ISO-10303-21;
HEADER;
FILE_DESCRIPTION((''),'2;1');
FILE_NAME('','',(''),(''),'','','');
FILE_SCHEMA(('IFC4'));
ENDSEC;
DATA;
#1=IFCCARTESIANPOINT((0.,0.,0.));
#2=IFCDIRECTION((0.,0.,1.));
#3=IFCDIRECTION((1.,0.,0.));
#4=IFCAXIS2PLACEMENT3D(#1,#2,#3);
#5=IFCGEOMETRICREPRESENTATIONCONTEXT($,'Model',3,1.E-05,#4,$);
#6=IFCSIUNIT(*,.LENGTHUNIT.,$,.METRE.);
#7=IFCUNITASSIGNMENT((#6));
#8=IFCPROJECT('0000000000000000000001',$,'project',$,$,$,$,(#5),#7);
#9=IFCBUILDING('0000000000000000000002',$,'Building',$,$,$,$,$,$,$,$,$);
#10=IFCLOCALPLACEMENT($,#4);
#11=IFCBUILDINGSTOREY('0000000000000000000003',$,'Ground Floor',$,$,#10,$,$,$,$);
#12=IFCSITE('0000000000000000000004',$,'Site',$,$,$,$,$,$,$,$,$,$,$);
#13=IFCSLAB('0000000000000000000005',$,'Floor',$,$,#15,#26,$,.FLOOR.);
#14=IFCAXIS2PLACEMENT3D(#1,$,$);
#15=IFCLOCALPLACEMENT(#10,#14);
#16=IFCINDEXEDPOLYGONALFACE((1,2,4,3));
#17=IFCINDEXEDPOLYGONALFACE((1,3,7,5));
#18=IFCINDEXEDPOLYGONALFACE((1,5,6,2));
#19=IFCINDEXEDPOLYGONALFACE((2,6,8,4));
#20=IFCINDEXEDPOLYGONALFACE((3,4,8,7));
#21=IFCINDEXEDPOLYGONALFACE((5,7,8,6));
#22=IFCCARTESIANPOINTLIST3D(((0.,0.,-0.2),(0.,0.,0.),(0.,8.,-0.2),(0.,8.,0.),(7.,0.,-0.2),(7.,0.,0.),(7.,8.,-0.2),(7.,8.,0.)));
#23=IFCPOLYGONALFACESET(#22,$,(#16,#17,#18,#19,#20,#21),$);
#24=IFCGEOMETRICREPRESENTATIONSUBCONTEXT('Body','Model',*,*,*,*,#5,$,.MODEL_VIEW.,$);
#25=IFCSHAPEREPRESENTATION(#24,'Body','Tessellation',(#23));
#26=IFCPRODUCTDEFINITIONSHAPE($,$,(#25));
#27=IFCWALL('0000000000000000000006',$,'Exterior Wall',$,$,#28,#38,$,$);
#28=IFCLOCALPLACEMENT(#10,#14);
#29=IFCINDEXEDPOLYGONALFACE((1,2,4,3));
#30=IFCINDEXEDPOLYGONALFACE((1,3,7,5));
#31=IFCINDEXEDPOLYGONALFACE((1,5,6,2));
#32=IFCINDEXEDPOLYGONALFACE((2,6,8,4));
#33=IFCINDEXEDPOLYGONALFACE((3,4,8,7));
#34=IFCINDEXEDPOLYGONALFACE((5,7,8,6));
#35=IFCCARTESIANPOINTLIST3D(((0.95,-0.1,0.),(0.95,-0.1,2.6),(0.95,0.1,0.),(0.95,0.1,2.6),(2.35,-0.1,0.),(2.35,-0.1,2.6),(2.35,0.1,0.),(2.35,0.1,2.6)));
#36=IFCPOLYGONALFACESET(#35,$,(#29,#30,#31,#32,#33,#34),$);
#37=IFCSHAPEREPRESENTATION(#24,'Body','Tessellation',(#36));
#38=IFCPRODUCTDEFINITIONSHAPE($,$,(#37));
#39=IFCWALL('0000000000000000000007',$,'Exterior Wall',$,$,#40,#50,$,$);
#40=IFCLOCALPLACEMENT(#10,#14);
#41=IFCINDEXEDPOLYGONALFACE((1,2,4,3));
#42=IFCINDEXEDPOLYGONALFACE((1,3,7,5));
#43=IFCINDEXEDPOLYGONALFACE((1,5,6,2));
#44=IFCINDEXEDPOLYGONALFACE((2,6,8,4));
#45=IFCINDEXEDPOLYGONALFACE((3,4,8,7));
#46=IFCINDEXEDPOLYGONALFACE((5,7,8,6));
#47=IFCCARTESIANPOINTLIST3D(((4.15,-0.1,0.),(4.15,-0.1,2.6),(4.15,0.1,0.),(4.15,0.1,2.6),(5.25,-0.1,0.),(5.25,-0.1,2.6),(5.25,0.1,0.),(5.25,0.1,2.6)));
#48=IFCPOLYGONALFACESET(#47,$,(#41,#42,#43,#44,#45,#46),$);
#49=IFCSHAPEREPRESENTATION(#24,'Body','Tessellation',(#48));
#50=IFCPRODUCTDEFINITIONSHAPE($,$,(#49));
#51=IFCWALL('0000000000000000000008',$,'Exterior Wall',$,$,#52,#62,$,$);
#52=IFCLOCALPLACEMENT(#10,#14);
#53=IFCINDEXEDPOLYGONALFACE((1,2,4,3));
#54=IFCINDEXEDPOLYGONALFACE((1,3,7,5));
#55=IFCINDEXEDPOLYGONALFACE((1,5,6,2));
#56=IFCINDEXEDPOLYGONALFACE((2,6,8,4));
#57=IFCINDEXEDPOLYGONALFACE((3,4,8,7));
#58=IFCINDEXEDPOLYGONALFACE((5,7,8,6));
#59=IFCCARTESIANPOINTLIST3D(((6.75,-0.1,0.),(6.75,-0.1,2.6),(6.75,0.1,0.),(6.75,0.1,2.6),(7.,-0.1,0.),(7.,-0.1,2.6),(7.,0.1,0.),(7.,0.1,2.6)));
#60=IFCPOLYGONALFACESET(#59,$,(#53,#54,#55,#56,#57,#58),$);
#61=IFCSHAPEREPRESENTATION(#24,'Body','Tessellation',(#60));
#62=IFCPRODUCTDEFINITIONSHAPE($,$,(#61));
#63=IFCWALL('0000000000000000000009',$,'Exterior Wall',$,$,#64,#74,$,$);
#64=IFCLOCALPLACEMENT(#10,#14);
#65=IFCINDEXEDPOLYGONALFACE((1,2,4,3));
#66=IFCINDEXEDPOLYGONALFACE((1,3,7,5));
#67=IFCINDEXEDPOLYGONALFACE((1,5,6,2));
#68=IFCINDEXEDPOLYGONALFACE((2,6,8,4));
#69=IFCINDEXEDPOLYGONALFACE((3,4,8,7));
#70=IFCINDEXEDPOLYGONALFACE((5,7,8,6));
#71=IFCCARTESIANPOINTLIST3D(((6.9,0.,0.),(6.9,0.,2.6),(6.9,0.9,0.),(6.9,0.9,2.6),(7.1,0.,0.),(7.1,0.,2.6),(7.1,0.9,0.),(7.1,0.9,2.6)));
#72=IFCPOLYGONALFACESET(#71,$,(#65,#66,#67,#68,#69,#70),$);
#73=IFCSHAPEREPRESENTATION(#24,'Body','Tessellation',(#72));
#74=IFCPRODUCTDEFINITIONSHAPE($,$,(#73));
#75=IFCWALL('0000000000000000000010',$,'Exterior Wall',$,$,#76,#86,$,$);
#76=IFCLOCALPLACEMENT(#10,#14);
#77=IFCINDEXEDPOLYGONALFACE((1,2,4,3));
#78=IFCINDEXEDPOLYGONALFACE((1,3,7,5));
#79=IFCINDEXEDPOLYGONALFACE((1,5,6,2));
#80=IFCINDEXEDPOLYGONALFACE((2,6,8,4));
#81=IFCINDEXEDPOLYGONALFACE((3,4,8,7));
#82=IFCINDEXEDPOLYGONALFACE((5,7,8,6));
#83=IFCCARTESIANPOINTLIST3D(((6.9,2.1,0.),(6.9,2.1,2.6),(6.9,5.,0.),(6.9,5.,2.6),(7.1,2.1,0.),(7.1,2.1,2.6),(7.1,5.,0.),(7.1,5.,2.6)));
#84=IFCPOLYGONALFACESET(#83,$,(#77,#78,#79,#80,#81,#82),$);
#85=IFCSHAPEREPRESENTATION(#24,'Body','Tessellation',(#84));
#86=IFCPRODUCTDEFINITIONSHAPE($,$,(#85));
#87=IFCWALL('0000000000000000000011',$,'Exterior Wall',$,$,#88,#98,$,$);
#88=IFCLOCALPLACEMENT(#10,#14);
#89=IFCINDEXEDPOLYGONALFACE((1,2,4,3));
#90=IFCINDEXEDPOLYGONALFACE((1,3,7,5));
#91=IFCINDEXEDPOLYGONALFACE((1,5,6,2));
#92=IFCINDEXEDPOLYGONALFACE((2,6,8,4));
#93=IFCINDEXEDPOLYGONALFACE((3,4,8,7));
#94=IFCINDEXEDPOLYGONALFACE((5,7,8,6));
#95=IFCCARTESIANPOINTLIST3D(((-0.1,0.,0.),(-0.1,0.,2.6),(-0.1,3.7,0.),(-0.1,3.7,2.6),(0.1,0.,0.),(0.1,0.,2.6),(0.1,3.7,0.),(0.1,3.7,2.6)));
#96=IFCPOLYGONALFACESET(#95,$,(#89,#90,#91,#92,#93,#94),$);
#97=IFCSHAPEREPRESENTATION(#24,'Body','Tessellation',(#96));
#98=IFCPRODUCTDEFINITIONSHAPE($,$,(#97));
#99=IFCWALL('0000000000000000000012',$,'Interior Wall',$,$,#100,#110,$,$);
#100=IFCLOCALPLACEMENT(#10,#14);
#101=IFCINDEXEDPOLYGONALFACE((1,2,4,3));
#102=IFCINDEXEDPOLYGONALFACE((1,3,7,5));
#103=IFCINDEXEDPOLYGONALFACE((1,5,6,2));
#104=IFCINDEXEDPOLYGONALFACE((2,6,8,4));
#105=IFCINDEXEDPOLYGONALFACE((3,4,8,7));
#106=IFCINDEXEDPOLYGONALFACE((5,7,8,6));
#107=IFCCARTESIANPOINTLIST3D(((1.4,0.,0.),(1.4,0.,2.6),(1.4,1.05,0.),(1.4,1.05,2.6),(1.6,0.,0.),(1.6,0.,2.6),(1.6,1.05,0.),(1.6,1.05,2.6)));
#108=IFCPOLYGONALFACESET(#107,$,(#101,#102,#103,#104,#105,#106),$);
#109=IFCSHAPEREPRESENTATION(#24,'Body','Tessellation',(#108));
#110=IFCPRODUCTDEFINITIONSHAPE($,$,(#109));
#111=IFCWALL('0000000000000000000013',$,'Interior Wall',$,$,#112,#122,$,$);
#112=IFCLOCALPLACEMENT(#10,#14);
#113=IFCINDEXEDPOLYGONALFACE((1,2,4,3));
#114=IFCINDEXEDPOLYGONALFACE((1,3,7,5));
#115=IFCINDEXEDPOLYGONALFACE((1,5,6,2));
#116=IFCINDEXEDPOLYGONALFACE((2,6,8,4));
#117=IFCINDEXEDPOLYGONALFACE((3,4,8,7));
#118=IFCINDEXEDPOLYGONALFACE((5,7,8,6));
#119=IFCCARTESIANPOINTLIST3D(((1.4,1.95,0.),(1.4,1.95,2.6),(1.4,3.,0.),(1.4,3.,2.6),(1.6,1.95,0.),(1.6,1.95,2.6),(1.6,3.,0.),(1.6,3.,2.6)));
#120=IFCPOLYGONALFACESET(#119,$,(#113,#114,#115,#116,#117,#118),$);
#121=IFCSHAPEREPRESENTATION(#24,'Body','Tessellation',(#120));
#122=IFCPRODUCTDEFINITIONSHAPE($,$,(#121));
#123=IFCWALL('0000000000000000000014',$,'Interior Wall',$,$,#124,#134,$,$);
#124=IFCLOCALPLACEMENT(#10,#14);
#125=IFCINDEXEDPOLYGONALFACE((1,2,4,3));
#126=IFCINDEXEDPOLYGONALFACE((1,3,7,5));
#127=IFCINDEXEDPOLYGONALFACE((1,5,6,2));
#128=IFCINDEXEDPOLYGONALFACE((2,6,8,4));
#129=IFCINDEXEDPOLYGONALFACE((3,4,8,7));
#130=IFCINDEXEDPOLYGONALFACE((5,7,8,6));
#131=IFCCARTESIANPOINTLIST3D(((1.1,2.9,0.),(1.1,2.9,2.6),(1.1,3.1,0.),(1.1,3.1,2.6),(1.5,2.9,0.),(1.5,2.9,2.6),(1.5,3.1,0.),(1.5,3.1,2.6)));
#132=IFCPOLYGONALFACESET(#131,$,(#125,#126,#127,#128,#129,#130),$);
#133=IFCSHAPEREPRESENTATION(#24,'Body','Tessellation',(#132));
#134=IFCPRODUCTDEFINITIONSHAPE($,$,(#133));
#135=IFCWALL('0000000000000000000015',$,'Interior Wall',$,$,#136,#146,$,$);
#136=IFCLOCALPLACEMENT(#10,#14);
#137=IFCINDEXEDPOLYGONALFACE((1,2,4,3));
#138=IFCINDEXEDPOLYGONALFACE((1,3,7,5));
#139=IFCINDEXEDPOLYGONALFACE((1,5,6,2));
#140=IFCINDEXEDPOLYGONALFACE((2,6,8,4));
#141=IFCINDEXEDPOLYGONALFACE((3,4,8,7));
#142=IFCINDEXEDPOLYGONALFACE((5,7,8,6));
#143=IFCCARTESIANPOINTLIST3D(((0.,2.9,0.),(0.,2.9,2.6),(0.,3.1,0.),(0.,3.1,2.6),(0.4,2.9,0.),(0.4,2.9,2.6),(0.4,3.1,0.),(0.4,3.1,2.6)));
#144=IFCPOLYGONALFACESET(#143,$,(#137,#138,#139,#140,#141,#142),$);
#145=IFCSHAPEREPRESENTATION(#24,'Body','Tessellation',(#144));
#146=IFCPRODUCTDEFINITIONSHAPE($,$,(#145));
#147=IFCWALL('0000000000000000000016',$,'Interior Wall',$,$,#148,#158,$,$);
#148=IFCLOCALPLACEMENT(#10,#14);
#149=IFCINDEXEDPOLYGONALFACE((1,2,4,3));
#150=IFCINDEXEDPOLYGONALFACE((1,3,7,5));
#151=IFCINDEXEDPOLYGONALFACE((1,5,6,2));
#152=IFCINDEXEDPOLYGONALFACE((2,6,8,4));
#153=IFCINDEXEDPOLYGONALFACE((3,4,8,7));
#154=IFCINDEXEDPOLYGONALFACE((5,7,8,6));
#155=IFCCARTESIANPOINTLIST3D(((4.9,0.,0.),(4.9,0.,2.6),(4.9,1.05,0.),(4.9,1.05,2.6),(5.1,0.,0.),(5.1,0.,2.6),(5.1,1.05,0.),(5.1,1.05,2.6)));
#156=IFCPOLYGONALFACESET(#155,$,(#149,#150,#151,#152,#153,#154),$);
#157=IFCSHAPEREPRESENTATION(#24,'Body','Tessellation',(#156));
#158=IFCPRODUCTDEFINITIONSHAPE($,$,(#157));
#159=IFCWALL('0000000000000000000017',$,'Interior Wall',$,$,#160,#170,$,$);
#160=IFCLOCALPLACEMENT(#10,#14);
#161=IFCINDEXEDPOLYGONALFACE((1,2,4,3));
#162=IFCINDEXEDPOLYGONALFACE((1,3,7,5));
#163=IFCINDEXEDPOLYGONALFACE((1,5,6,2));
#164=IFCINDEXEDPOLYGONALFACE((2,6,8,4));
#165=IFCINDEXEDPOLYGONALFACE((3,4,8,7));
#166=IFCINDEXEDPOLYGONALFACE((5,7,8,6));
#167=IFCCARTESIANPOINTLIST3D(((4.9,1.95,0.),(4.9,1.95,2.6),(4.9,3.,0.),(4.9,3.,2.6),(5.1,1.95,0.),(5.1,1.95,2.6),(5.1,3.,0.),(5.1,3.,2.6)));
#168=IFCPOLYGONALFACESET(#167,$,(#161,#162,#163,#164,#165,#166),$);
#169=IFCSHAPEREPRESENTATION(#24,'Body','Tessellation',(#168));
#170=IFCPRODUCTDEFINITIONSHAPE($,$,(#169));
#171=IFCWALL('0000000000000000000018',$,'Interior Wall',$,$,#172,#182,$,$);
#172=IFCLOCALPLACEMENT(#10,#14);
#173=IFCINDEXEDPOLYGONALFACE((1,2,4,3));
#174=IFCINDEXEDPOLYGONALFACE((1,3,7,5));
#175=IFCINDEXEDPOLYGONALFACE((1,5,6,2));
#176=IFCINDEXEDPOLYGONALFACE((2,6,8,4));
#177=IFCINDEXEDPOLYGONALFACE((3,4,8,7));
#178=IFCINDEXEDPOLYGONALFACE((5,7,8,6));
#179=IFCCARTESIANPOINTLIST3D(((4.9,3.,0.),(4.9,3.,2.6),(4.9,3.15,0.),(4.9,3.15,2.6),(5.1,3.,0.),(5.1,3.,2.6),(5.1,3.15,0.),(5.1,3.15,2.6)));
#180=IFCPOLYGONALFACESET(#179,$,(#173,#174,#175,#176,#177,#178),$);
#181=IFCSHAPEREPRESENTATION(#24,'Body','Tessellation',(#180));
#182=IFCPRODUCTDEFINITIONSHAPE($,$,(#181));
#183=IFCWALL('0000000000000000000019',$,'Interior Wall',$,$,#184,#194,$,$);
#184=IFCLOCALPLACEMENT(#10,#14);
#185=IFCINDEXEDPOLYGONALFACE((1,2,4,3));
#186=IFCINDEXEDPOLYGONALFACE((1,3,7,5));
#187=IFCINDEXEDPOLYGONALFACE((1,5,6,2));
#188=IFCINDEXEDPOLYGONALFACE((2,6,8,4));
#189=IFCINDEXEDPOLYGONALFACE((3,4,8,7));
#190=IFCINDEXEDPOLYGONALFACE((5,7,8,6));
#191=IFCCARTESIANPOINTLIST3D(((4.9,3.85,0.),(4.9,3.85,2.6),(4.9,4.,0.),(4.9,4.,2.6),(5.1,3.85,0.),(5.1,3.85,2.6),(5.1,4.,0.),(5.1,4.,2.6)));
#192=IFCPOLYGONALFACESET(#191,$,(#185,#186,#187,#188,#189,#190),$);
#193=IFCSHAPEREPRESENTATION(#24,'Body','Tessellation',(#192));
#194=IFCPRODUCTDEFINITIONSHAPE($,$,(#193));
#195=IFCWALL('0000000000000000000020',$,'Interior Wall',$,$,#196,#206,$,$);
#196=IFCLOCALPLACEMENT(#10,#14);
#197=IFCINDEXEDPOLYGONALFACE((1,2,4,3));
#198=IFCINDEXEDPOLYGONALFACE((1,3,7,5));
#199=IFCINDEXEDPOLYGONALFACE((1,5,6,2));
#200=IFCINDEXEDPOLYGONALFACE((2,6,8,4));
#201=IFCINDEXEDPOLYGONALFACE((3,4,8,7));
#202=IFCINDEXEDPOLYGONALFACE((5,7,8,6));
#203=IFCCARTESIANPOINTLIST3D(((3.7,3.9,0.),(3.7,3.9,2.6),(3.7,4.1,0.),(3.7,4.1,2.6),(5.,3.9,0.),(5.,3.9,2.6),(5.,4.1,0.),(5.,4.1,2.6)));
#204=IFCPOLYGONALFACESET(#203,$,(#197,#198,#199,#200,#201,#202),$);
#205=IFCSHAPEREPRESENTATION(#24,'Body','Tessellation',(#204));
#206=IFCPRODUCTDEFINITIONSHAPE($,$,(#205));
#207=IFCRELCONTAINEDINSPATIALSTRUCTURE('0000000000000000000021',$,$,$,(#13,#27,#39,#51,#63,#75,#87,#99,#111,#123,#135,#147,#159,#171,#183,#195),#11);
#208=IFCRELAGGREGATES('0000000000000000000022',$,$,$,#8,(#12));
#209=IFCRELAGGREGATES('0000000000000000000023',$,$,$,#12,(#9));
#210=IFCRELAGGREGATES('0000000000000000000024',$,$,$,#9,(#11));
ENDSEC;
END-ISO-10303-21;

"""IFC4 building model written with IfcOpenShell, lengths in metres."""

from ifc_helpers import new_model, si_unit, frame, origin_with_axes, place, context, subcontext, project, spatial, indexed_curve, outline, extrude, element, save


model = new_model("IFC4")

# Units and contexts
model_context = context("Model", 3, precision=1e-05, world=origin_with_axes())
body_context = subcontext(model_context, "Body", "Model", "MODEL_VIEW")
ifc_project = project(units=[si_unit("LENGTHUNIT", "METRE")], contexts=[model_context])

# Site, building, storey
site = spatial("IfcSite", under=ifc_project, Name="Site")
building = spatial("IfcBuilding", under=site, Name="Building")
storey_placement = place(None, origin_with_axes())
storey = spatial("IfcBuildingStorey", under=building, at=storey_placement, Name="Ground Floor")

# Slab
slab_placement = place(storey_placement, frame((0.0, 0.0, -0.2), z_axis=(0.0, 0.0, 1.0), x_axis=(1.0, 0.0, 0.0)))
element("IfcSlab", 1, at=slab_placement, inside=storey, Name="Floor", PredefinedType="FLOOR", context=body_context, shape_type="SweptSolid", body=[
    extrude(outline(indexed_curve([(0.0, 0.0), (7.0, 0.0), (7.0, 8.0), (0.0, 8.0)])), None, (0.0, 0.0, 1.0), 0.2),
])

# Walls
wall_1_placement = place(storey_placement, frame((0.95, 0.0, 0.0), z_axis=(0.0, 0.0, 1.0), x_axis=(1.0, 0.0, 0.0)))
element("IfcWall", 2, at=wall_1_placement, inside=storey, Name="Exterior Wall", context=body_context, shape_type="SweptSolid", body=[
    extrude(outline(indexed_curve([(0.0, 0.0), (0.0, 0.2), (1.4, 0.2), (1.4, 0.0), (0.0, 0.0)], self_intersect=False)), frame((0.0, -0.1, 0.0), z_axis=(0.0, 0.0, 1.0), x_axis=(1.0, 0.0, 0.0)), (0.0, 0.0, 1.0), 2.6),
])
wall_2_placement = place(storey_placement, frame((4.15, 0.0, 0.0), z_axis=(0.0, 0.0, 1.0), x_axis=(1.0, 0.0, 0.0)))
element("IfcWall", 3, at=wall_2_placement, inside=storey, Name="Exterior Wall", context=body_context, shape_type="SweptSolid", body=[
    extrude(outline(indexed_curve([(0.0, 0.0), (0.0, 0.2), (1.1, 0.2), (1.1, 0.0), (0.0, 0.0)], self_intersect=False)), frame((0.0, -0.1, 0.0), z_axis=(0.0, 0.0, 1.0), x_axis=(1.0, 0.0, 0.0)), (0.0, 0.0, 1.0), 2.6),
])
wall_3_placement = place(storey_placement, frame((6.75, 0.0, 0.0), z_axis=(0.0, 0.0, 1.0), x_axis=(1.0, 0.0, 0.0)))
element("IfcWall", 4, at=wall_3_placement, inside=storey, Name="Exterior Wall", context=body_context, shape_type="SweptSolid", body=[
    extrude(outline(indexed_curve([(0.0, 0.0), (0.0, 0.2), (0.25, 0.2), (0.25, 0.0), (0.0, 0.0)], self_intersect=False)), frame((0.0, -0.1, 0.0), z_axis=(0.0, 0.0, 1.0), x_axis=(1.0, 0.0, 0.0)), (0.0, 0.0, 1.0), 2.6),
])
wall_4_placement = place(storey_placement, frame((7.0, 0.0, 0.0), z_axis=(0.0, 0.0, 1.0), x_axis=(0.0, 1.0, 0.0)))
element("IfcWall", 5, at=wall_4_placement, inside=storey, Name="Exterior Wall", context=body_context, shape_type="SweptSolid", body=[
    extrude(outline(indexed_curve([(0.0, 0.0), (0.0, 0.2), (0.9, 0.2), (0.9, 0.0), (0.0, 0.0)], self_intersect=False)), frame((0.0, -0.1, 0.0), z_axis=(0.0, 0.0, 1.0), x_axis=(1.0, 0.0, 0.0)), (0.0, 0.0, 1.0), 2.6),
])
wall_5_placement = place(storey_placement, frame((7.0, 2.1, 0.0), z_axis=(0.0, 0.0, 1.0), x_axis=(0.0, 1.0, 0.0)))
element("IfcWall", 6, at=wall_5_placement, inside=storey, Name="Exterior Wall", context=body_context, shape_type="SweptSolid", body=[
    extrude(outline(indexed_curve([(0.0, 0.0), (0.0, 0.2), (2.9, 0.2), (2.9, 0.0), (0.0, 0.0)], self_intersect=False)), frame((0.0, -0.1, 0.0), z_axis=(0.0, 0.0, 1.0), x_axis=(1.0, 0.0, 0.0)), (0.0, 0.0, 1.0), 2.6),
])
wall_6_placement = place(storey_placement, frame((0.0, 3.7, 0.0), z_axis=(0.0, 0.0, 1.0), x_axis=(0.0, -1.0, 0.0)))
element("IfcWall", 7, at=wall_6_placement, inside=storey, Name="Exterior Wall", context=body_context, shape_type="SweptSolid", body=[
    extrude(outline(indexed_curve([(0.0, 0.0), (0.0, 0.2), (3.7, 0.2), (3.7, 0.0), (0.0, 0.0)], self_intersect=False)), frame((0.0, -0.1, 0.0), z_axis=(0.0, 0.0, 1.0), x_axis=(1.0, 0.0, 0.0)), (0.0, 0.0, 1.0), 2.6),
])
for number, where, z_axis, x_axis, name in (
    (8, (1.5, 0.0, 0.0), (0.0, 0.0, 1.0), (0.0, 1.0, 0.0), "Interior Wall"),
    (9, (1.5, 1.95, 0.0), (0.0, 0.0, 1.0), (0.0, 1.0, 0.0), "Interior Wall"),
):
    element("IfcWall", number, at=place(storey_placement, frame(where, z_axis=z_axis, x_axis=x_axis)), inside=storey, Name=name, context=body_context, shape_type="SweptSolid", body=[
        extrude(outline(indexed_curve([(0.0, 0.0), (0.0, 0.2), (1.05, 0.2), (1.05, 0.0), (0.0, 0.0)], self_intersect=False)), frame((0.0, -0.1, 0.0), z_axis=(0.0, 0.0, 1.0), x_axis=(1.0, 0.0, 0.0)), (0.0, 0.0, 1.0), 2.6),
    ])
for number, where, z_axis, x_axis, name in (
    (10, (1.5, 3.0, 0.0), (0.0, 0.0, 1.0), (-1.0, 0.0, 0.0), "Interior Wall"),
    (11, (0.4, 3.0, 0.0), (0.0, 0.0, 1.0), (-1.0, 0.0, 0.0), "Interior Wall"),
):
    element("IfcWall", number, at=place(storey_placement, frame(where, z_axis=z_axis, x_axis=x_axis)), inside=storey, Name=name, context=body_context, shape_type="SweptSolid", body=[
        extrude(outline(indexed_curve([(0.0, 0.0), (0.0, 0.2), (0.4, 0.2), (0.4, 0.0), (0.0, 0.0)], self_intersect=False)), frame((0.0, -0.1, 0.0), z_axis=(0.0, 0.0, 1.0), x_axis=(1.0, 0.0, 0.0)), (0.0, 0.0, 1.0), 2.6),
    ])
for number, where, z_axis, x_axis, name in (
    (12, (5.0, 0.0, 0.0), (0.0, 0.0, 1.0), (0.0, 1.0, 0.0), "Interior Wall"),
    (13, (5.0, 1.95, 0.0), (0.0, 0.0, 1.0), (0.0, 1.0, 0.0), "Interior Wall"),
):
    element("IfcWall", number, at=place(storey_placement, frame(where, z_axis=z_axis, x_axis=x_axis)), inside=storey, Name=name, context=body_context, shape_type="SweptSolid", body=[
        extrude(outline(indexed_curve([(0.0, 0.0), (0.0, 0.2), (1.05, 0.2), (1.05, 0.0), (0.0, 0.0)], self_intersect=False)), frame((0.0, -0.1, 0.0), z_axis=(0.0, 0.0, 1.0), x_axis=(1.0, 0.0, 0.0)), (0.0, 0.0, 1.0), 2.6),
    ])
for number, where, z_axis, x_axis, name in (
    (14, (5.0, 3.0, 0.0), (0.0, 0.0, 1.0), (0.0, 1.0, 0.0), "Interior Wall"),
    (15, (5.0, 3.85, 0.0), (0.0, 0.0, 1.0), (0.0, 1.0, 0.0), "Interior Wall"),
):
    element("IfcWall", number, at=place(storey_placement, frame(where, z_axis=z_axis, x_axis=x_axis)), inside=storey, Name=name, context=body_context, shape_type="SweptSolid", body=[
        extrude(outline(indexed_curve([(0.0, 0.0), (0.0, 0.2), (0.15, 0.2), (0.15, 0.0), (0.0, 0.0)], self_intersect=False)), frame((0.0, -0.1, 0.0), z_axis=(0.0, 0.0, 1.0), x_axis=(1.0, 0.0, 0.0)), (0.0, 0.0, 1.0), 2.6),
    ])
for number, where, z_axis, x_axis, name in (
    (16, (5.0, 4.0, 0.0), (0.0, 0.0, 1.0), (-1.0, 0.0, 0.0), "Interior Wall"),
):
    element("IfcWall", number, at=place(storey_placement, frame(where, z_axis=z_axis, x_axis=x_axis)), inside=storey, Name=name, context=body_context, shape_type="SweptSolid", body=[
        extrude(outline(indexed_curve([(0.0, 0.0), (0.0, 0.2), (1.3, 0.2), (1.3, 0.0), (0.0, 0.0)], self_intersect=False)), frame((0.0, -0.1, 0.0), z_axis=(0.0, 0.0, 1.0), x_axis=(1.0, 0.0, 0.0)), (0.0, 0.0, 1.0), 2.6),
    ])

save(model, "model.ifc")
